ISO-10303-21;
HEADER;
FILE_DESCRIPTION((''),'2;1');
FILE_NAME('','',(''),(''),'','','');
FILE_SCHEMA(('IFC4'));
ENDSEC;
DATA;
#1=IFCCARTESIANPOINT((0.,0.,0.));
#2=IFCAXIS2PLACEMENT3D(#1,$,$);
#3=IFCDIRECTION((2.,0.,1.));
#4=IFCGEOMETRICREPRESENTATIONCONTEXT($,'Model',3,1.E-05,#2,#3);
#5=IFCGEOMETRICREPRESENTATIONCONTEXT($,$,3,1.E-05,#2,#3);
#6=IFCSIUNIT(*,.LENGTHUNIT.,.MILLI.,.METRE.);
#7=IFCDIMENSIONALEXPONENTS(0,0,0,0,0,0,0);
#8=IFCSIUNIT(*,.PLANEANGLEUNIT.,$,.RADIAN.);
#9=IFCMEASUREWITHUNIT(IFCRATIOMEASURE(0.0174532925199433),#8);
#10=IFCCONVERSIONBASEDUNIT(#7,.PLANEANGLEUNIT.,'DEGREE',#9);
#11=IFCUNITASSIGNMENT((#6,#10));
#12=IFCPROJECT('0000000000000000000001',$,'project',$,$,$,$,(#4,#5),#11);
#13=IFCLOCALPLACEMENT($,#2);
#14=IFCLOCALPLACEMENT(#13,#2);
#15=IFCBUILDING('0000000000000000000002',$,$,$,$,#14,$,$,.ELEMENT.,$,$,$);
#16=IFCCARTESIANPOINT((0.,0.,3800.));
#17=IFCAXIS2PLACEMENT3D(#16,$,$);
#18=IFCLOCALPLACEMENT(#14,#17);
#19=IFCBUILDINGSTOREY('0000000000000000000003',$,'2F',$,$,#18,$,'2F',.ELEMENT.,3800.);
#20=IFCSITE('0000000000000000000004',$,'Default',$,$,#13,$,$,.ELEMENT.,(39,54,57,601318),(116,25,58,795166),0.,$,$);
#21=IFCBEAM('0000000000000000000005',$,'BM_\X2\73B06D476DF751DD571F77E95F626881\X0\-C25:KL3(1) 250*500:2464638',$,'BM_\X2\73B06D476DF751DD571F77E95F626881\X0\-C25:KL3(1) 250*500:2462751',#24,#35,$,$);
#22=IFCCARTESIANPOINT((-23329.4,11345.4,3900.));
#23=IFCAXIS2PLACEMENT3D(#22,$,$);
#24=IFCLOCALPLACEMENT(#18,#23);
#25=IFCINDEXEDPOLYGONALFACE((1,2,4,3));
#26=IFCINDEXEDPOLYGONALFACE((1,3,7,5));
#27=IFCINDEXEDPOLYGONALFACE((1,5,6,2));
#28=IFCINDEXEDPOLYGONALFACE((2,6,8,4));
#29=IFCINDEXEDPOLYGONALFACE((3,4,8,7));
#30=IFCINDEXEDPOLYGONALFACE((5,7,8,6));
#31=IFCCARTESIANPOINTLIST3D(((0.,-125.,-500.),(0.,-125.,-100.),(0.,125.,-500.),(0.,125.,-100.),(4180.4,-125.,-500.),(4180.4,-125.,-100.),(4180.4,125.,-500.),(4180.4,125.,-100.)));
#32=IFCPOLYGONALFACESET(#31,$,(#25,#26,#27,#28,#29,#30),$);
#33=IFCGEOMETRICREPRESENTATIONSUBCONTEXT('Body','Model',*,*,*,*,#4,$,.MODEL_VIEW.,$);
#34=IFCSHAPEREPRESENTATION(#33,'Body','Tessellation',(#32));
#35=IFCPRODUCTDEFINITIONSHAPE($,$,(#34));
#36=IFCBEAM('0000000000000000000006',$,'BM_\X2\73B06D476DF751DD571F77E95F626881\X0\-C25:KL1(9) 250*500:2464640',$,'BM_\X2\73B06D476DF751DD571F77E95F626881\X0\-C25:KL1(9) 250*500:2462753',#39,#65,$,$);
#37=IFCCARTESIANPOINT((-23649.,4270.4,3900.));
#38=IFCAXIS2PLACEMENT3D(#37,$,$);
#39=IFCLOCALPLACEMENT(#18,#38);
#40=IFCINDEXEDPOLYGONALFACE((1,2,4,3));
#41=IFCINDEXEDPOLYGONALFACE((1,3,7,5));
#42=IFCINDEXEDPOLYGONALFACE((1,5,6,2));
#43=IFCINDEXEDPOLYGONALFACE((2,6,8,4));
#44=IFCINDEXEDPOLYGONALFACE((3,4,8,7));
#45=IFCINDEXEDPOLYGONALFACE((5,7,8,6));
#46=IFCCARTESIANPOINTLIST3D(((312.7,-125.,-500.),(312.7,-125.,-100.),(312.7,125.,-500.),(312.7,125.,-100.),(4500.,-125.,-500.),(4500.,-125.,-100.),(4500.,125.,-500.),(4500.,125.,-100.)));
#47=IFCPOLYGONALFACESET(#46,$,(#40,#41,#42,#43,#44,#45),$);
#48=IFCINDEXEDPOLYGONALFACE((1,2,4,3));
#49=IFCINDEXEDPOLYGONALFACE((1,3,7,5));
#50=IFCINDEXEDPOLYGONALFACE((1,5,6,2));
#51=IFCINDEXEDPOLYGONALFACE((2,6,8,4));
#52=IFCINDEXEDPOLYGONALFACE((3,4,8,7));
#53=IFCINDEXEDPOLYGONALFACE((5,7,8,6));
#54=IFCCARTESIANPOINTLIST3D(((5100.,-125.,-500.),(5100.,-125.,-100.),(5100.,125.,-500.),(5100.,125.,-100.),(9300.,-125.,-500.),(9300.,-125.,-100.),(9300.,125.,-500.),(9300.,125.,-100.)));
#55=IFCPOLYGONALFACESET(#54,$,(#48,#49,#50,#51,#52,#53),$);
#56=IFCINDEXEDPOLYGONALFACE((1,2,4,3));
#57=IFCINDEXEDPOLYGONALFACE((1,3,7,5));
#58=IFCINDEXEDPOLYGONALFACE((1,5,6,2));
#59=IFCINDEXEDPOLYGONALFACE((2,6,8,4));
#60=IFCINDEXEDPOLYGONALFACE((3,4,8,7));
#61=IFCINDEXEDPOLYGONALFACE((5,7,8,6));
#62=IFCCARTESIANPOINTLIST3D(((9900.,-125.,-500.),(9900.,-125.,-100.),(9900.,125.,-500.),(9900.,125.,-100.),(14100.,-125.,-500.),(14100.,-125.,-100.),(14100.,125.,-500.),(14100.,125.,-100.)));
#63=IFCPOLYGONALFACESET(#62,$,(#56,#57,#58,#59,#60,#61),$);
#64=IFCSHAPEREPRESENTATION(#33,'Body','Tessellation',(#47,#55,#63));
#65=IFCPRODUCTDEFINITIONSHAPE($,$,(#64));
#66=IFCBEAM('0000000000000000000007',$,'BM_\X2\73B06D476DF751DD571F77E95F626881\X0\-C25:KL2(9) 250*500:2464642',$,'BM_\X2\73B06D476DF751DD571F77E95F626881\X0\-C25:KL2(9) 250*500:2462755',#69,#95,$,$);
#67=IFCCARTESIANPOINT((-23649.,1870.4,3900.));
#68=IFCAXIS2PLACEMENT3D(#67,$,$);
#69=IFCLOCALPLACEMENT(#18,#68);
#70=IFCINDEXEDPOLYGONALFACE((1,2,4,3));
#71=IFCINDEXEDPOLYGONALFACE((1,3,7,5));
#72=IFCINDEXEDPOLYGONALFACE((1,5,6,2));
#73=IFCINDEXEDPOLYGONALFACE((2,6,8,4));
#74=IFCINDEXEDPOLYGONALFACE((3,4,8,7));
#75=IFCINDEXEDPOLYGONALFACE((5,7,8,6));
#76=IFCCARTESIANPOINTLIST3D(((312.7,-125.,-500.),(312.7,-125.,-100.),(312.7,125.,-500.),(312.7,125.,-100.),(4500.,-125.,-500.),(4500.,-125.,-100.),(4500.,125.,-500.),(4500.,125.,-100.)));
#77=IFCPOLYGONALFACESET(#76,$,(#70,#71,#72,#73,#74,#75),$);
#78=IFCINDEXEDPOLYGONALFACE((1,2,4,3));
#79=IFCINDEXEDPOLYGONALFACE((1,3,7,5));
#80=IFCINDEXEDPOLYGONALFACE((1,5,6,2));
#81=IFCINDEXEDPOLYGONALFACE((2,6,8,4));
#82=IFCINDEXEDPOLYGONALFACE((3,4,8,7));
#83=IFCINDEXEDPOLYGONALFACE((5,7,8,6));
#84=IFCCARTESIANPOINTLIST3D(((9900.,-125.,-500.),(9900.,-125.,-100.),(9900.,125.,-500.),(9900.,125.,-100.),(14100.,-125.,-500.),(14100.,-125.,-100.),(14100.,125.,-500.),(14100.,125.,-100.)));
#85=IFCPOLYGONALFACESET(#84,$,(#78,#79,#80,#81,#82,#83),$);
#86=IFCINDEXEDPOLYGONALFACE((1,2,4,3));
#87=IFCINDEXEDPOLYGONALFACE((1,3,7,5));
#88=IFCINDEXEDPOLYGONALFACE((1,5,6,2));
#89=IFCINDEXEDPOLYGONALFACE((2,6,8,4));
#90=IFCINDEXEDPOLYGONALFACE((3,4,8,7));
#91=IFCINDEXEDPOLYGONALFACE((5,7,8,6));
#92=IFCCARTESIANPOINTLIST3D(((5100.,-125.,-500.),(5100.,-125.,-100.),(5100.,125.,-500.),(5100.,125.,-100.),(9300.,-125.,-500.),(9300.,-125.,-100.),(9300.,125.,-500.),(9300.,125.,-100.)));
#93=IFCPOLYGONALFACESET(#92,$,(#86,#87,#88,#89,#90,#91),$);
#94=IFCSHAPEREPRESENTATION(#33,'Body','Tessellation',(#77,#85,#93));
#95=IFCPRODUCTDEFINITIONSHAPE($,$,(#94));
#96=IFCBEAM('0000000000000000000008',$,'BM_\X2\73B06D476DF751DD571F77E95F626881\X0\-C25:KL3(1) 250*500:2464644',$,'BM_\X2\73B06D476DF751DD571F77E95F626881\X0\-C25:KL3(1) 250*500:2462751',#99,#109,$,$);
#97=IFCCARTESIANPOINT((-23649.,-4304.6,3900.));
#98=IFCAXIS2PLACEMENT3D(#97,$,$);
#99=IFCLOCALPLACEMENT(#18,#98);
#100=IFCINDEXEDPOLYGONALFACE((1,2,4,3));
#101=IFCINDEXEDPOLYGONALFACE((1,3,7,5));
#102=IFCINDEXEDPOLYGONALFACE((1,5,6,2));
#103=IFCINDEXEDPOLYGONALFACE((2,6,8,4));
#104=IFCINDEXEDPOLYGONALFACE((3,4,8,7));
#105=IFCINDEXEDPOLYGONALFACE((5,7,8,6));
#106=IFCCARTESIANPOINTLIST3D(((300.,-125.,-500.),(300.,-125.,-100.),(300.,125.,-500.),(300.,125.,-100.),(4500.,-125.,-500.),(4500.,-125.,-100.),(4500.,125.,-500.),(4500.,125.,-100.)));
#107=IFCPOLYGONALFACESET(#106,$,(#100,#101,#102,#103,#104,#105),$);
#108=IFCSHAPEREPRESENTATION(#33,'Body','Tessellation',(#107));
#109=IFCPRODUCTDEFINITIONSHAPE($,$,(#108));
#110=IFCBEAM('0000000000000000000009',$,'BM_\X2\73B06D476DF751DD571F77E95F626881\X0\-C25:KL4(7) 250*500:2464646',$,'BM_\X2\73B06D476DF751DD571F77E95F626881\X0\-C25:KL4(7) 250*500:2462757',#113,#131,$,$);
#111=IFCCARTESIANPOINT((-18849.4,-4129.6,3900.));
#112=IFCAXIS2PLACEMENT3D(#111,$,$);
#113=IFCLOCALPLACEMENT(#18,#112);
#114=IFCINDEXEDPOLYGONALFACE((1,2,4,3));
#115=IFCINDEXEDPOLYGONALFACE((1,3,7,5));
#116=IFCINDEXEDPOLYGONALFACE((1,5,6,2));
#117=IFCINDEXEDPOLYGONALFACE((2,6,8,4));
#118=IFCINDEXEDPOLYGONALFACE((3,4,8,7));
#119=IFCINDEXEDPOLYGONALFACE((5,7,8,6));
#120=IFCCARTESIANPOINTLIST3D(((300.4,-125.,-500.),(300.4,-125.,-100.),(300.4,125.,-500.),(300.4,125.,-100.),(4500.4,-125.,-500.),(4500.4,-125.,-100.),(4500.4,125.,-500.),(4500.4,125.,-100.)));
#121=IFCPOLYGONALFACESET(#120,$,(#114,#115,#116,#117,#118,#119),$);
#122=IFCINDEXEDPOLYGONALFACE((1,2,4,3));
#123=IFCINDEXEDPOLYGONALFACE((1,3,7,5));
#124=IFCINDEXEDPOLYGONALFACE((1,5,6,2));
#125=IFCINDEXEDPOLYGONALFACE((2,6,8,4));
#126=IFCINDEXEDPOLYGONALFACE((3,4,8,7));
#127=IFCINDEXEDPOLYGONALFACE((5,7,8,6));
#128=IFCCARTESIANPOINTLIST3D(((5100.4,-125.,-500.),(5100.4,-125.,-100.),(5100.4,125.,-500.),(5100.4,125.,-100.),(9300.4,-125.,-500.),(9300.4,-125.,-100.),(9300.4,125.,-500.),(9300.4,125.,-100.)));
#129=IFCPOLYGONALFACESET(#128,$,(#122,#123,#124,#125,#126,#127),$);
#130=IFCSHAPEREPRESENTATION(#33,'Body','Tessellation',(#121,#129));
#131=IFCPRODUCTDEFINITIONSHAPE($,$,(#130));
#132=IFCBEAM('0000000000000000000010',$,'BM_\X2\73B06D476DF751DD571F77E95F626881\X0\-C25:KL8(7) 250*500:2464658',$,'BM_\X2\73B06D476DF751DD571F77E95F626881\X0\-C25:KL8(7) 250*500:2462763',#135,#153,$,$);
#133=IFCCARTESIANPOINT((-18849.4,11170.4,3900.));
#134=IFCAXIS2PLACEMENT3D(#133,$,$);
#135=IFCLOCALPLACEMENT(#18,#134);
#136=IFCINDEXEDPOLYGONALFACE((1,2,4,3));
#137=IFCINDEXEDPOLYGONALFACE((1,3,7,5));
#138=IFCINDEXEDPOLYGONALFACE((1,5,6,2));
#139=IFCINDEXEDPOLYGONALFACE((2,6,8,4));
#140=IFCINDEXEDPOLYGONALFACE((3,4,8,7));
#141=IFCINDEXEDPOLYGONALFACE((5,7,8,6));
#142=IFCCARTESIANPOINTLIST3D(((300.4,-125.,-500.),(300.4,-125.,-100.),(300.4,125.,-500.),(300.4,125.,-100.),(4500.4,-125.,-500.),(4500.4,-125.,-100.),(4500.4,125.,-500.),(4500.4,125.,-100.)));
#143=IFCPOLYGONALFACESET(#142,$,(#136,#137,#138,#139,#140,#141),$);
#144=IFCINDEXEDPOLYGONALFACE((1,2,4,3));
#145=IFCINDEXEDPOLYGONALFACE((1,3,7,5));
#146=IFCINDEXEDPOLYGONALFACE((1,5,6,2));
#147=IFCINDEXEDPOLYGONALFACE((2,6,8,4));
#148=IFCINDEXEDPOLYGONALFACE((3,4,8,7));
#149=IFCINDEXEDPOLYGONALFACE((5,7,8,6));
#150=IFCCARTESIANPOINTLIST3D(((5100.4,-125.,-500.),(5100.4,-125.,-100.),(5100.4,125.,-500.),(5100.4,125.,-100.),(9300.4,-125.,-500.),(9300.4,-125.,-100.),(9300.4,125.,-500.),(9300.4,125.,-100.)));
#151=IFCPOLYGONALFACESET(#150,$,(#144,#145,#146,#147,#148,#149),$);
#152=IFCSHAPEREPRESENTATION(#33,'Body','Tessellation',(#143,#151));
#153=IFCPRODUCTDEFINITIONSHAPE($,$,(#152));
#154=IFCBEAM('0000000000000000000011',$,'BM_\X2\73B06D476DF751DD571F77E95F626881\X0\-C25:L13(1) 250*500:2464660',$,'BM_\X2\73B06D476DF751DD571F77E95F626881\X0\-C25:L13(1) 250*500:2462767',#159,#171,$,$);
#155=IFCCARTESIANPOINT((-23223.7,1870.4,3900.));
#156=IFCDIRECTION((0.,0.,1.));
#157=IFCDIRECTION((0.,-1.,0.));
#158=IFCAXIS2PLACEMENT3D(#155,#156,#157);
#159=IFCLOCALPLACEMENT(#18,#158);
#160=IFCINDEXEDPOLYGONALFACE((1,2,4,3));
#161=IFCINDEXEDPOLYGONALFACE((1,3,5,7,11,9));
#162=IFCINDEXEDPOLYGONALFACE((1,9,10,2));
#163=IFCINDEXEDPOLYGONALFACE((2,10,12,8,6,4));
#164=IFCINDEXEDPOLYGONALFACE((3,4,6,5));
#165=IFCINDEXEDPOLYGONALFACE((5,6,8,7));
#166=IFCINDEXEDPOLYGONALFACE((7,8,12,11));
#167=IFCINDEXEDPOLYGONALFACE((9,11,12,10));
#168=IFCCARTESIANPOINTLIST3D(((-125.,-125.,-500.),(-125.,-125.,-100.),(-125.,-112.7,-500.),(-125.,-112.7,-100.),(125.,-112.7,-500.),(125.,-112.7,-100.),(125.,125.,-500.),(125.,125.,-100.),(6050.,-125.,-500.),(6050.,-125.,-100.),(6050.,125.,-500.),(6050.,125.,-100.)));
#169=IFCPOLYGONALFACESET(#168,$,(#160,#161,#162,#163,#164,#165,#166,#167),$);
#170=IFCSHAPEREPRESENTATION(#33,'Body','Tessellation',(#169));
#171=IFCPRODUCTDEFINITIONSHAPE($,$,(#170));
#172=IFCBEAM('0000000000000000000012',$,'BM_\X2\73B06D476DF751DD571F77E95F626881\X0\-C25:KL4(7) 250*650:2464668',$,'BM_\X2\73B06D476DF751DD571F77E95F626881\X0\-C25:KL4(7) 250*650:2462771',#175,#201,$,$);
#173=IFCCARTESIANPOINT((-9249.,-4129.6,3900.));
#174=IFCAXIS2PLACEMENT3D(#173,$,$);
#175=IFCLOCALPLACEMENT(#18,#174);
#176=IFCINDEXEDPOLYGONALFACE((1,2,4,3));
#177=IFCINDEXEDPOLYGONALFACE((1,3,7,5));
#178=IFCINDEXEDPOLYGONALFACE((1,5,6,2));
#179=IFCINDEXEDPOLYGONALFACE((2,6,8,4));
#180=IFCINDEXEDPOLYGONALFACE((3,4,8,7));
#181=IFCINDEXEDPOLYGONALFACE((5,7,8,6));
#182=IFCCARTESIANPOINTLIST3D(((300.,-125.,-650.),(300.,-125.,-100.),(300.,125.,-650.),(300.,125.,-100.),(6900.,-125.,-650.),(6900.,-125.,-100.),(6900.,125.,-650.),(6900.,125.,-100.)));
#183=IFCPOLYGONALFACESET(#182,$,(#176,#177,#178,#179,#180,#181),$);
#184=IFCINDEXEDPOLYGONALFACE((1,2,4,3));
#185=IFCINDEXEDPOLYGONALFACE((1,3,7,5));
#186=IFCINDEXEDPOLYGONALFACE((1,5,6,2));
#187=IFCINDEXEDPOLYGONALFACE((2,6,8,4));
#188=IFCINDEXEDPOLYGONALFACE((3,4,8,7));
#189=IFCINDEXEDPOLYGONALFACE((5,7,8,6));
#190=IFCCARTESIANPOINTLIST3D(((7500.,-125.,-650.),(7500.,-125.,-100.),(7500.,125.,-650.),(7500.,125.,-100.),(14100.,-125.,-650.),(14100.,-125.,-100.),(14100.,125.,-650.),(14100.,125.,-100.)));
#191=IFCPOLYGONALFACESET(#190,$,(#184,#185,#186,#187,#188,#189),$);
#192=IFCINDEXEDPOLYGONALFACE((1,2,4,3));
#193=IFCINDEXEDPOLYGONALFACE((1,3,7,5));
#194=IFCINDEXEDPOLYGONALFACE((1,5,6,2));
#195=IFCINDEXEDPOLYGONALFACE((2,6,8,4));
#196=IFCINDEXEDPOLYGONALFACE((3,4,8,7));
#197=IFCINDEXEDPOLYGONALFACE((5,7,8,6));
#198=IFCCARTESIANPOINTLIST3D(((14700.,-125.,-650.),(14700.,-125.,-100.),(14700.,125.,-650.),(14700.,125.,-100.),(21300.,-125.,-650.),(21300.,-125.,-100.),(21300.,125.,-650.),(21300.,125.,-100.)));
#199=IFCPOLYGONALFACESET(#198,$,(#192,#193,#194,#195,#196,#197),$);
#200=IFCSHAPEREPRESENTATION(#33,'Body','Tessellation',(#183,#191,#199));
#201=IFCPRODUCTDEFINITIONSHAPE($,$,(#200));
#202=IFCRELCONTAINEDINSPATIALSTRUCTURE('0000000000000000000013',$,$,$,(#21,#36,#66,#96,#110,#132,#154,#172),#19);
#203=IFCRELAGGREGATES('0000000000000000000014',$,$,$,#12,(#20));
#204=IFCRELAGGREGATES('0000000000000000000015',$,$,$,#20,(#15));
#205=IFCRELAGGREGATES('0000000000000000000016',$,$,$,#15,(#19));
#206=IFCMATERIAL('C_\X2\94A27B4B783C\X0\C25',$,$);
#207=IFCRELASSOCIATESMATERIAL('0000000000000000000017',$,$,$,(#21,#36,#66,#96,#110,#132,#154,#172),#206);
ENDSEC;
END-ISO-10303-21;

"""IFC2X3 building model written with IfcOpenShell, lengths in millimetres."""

from ifc_helpers import new_model, entity, si_unit, converted_unit, direction, frame, frame_2d, origin, place, context, subcontext, project, spatial, polyline, rectangle, extrude, clip, bounded_halfspace, material, element, save


model = new_model("IFC2X3")

# Units and contexts
model_context = context("Model", 3, precision=1e-05, world=origin(), true_north=direction((2.0, 0.0, 1.0)))
context_of_model = context(None, 3, precision=1e-05, world=origin(), true_north=direction((2.0, 0.0, 1.0)))
body_context = subcontext(model_context, "Body", "Model", "MODEL_VIEW")
ifc_project = project(units=[si_unit("LENGTHUNIT", "METRE", prefix="MILLI"), converted_unit("PLANEANGLEUNIT", "DEGREE", entity("IfcRatioMeasure", 0.0174532925199433), si_unit("PLANEANGLEUNIT", "RADIAN"), dimensions=[0, 0, 0, 0, 0, 0, 0])], contexts=[model_context, context_of_model])

# Site, building, storey
site_placement = place(None, origin())
site = spatial("IfcSite", under=ifc_project, at=site_placement, Name="Default", CompositionType="ELEMENT", RefLatitude=(39, 54, 57, 601318), RefLongitude=(116, 25, 58, 795166), RefElevation=0.0)
building_placement = place(site_placement, origin())
building = spatial("IfcBuilding", under=site, at=building_placement, CompositionType="ELEMENT")
storey_placement = place(building_placement, frame((0.0, 0.0, 3800.0)))
storey = spatial("IfcBuildingStorey", under=building, at=storey_placement, Name="2F", LongName="2F", CompositionType="ELEMENT", Elevation=3800.0)

# Beams
ifc_material_1 = material(Name="C_钢筋砼C25")
beam_1_placement = place(storey_placement, frame((-23329.4, 11345.4, 3900.0)))
element("IfcBeam", 1, at=beam_1_placement, inside=storey, material=ifc_material_1, Name="BM_现浇混凝土矩形梁-C25:KL3(1) 250*500:2464638", ObjectType="BM_现浇混凝土矩形梁-C25:KL3(1) 250*500:2462751", context=body_context, shape_type="SweptSolid", body=[
    extrude(rectangle(XDim=400.0, YDim=250.0, at=frame_2d((0.0, 0.0), x_axis=(1.0, 0.0))), frame((0.0, 0.0, -300.0), z_axis=(1.0, 0.0, 0.0), x_axis=(0.0, 0.0, -1.0)), (0.0, 0.0, 1.0), 4180.4),
])
beam_2_placement = place(storey_placement, frame((-23649.0, 4270.4, 3900.0)))
element("IfcBeam", 2, at=beam_2_placement, inside=storey, material=ifc_material_1, Name="BM_现浇混凝土矩形梁-C25:KL1(9) 250*500:2464640", ObjectType="BM_现浇混凝土矩形梁-C25:KL1(9) 250*500:2462753", context=body_context, shape_type="SweptSolid", body=[
    extrude(rectangle(XDim=400.0, YDim=250.0, at=frame_2d((0.0, 0.0), x_axis=(1.0, 0.0))), frame((312.7, 0.0, -300.0), z_axis=(1.0, 0.0, 0.0), x_axis=(0.0, 0.0, 1.0)), (0.0, 0.0, 1.0), 4187.3),
    extrude(rectangle(XDim=400.0, YDim=250.0, at=frame_2d((0.0, 0.0), x_axis=(1.0, 0.0))), frame((5100.0, 0.0, -300.0), z_axis=(1.0, 0.0, 0.0), x_axis=(0.0, 0.0, 1.0)), (0.0, 0.0, 1.0), 4200.0),
    extrude(rectangle(XDim=400.0, YDim=250.0, at=frame_2d((0.0, 0.0), x_axis=(1.0, 0.0))), frame((9900.0, 0.0, -300.0), z_axis=(1.0, 0.0, 0.0), x_axis=(0.0, 0.0, 1.0)), (0.0, 0.0, 1.0), 4200.0),
])
beam_3_placement = place(storey_placement, frame((-23649.0, 1870.4, 3900.0)))
element("IfcBeam", 3, at=beam_3_placement, inside=storey, material=ifc_material_1, Name="BM_现浇混凝土矩形梁-C25:KL2(9) 250*500:2464642", ObjectType="BM_现浇混凝土矩形梁-C25:KL2(9) 250*500:2462755", context=body_context, shape_type="SweptSolid", body=[
    extrude(rectangle(XDim=400.0, YDim=250.0, at=frame_2d((0.0, 0.0), x_axis=(1.0, 0.0))), frame((312.7, 0.0, -300.0), z_axis=(1.0, 0.0, 0.0), x_axis=(0.0, 0.0, 1.0)), (0.0, 0.0, 1.0), 4187.3),
    extrude(rectangle(XDim=400.0, YDim=250.0, at=frame_2d((0.0, 0.0), x_axis=(1.0, 0.0))), frame((9900.0, 0.0, -300.0), z_axis=(1.0, 0.0, 0.0), x_axis=(0.0, 0.0, 1.0)), (0.0, 0.0, 1.0), 4200.0),
    extrude(rectangle(XDim=400.0, YDim=250.0, at=frame_2d((0.0, 0.0), x_axis=(1.0, 0.0))), frame((5100.0, 0.0, -300.0), z_axis=(1.0, 0.0, 0.0), x_axis=(0.0, 0.0, 1.0)), (0.0, 0.0, 1.0), 4200.0),
])
beam_4_placement = place(storey_placement, frame((-23649.0, -4304.6, 3900.0)))
element("IfcBeam", 4, at=beam_4_placement, inside=storey, material=ifc_material_1, Name="BM_现浇混凝土矩形梁-C25:KL3(1) 250*500:2464644", ObjectType="BM_现浇混凝土矩形梁-C25:KL3(1) 250*500:2462751", context=body_context, shape_type="SweptSolid", body=[
    extrude(rectangle(XDim=400.0, YDim=250.0, at=frame_2d((0.0, 0.0), x_axis=(1.0, 0.0))), frame((300.0, 0.0, -300.0), z_axis=(1.0, 0.0, 0.0), x_axis=(0.0, 0.0, -1.0)), (0.0, 0.0, 1.0), 4200.0),
])
beam_5_placement = place(storey_placement, frame((-18849.4, -4129.6, 3900.0)))
element("IfcBeam", 5, at=beam_5_placement, inside=storey, material=ifc_material_1, Name="BM_现浇混凝土矩形梁-C25:KL4(7) 250*500:2464646", ObjectType="BM_现浇混凝土矩形梁-C25:KL4(7) 250*500:2462757", context=body_context, shape_type="SweptSolid", body=[
    extrude(rectangle(XDim=400.0, YDim=250.0, at=frame_2d((0.0, 0.0), x_axis=(1.0, 0.0))), frame((300.4, 0.0, -300.0), z_axis=(1.0, 0.0, 0.0), x_axis=(0.0, 0.0, 1.0)), (0.0, 0.0, 1.0), 4200.0),
    extrude(rectangle(XDim=400.0, YDim=250.0, at=frame_2d((0.0, 0.0), x_axis=(1.0, 0.0))), frame((5100.4, 0.0, -300.0), z_axis=(1.0, 0.0, 0.0), x_axis=(0.0, 0.0, 1.0)), (0.0, 0.0, 1.0), 4200.0),
])
beam_6_placement = place(storey_placement, frame((-18849.4, 11170.4, 3900.0)))
element("IfcBeam", 6, at=beam_6_placement, inside=storey, material=ifc_material_1, Name="BM_现浇混凝土矩形梁-C25:KL8(7) 250*500:2464658", ObjectType="BM_现浇混凝土矩形梁-C25:KL8(7) 250*500:2462763", context=body_context, shape_type="SweptSolid", body=[
    extrude(rectangle(XDim=400.0, YDim=250.0, at=frame_2d((0.0, 0.0), x_axis=(1.0, 0.0))), frame((300.4, 0.0, -300.0), z_axis=(1.0, 0.0, 0.0), x_axis=(0.0, 0.0, 1.0)), (0.0, 0.0, 1.0), 4200.0),
    extrude(rectangle(XDim=400.0, YDim=250.0, at=frame_2d((0.0, 0.0), x_axis=(1.0, 0.0))), frame((5100.4, 0.0, -300.0), z_axis=(1.0, 0.0, 0.0), x_axis=(0.0, 0.0, 1.0)), (0.0, 0.0, 1.0), 4200.0),
])
beam_7_placement = place(storey_placement, frame((-23223.7, 1870.4, 3900.0), z_axis=(0.0, 0.0, 1.0), x_axis=(0.0, -1.0, 0.0)))
element("IfcBeam", 7, at=beam_7_placement, inside=storey, material=ifc_material_1, Name="BM_现浇混凝土矩形梁-C25:L13(1) 250*500:2464660", ObjectType="BM_现浇混凝土矩形梁-C25:L13(1) 250*500:2462767", context=body_context, shape_type="Clipping", body=[
    clip(extrude(rectangle(XDim=400.0, YDim=250.0, at=frame_2d((0.0, 0.0), x_axis=(1.0, 0.0))), frame((-125.0, 0.0, -300.0), z_axis=(1.0, 0.0, 0.0), x_axis=(0.0, 0.0, -1.0)), (0.0, 0.0, 1.0), 6175.0), bounded_halfspace(frame((125.0, -112.7, -500.0), z_axis=(-1.0, 0.0, 0.0), x_axis=(0.0, 0.0, 1.0)), False, frame((-125.0, 0.0, -300.0), z_axis=(1.0, 0.0, 0.0), x_axis=(0.0, 0.0, -1.0)), polyline([(200.0, 125.0), (200.0, -112.7), (-200.0, -112.7), (-200.0, 125.0), (200.0, 125.0)]))),
])
beam_8_placement = place(storey_placement, frame((-9249.0, -4129.6, 3900.0)))
element("IfcBeam", 8, at=beam_8_placement, inside=storey, material=ifc_material_1, Name="BM_现浇混凝土矩形梁-C25:KL4(7) 250*650:2464668", ObjectType="BM_现浇混凝土矩形梁-C25:KL4(7) 250*650:2462771", context=body_context, shape_type="SweptSolid", body=[
    extrude(rectangle(XDim=550.0, YDim=250.0, at=frame_2d((0.0, 0.0), x_axis=(1.0, 0.0))), frame((300.0, 0.0, -375.0), z_axis=(1.0, 0.0, 0.0), x_axis=(0.0, 0.0, 1.0)), (0.0, 0.0, 1.0), 6600.0),
    extrude(rectangle(XDim=550.0, YDim=250.0, at=frame_2d((0.0, 0.0), x_axis=(1.0, 0.0))), frame((7500.0, 0.0, -375.0), z_axis=(1.0, 0.0, 0.0), x_axis=(0.0, 0.0, 1.0)), (0.0, 0.0, 1.0), 6600.0),
    extrude(rectangle(XDim=550.0, YDim=250.0, at=frame_2d((0.0, 0.0), x_axis=(1.0, 0.0))), frame((14700.0, 0.0, -375.0), z_axis=(1.0, 0.0, 0.0), x_axis=(0.0, 0.0, 1.0)), (0.0, 0.0, 1.0), 6600.0),
])

save(model, "model.ifc")
